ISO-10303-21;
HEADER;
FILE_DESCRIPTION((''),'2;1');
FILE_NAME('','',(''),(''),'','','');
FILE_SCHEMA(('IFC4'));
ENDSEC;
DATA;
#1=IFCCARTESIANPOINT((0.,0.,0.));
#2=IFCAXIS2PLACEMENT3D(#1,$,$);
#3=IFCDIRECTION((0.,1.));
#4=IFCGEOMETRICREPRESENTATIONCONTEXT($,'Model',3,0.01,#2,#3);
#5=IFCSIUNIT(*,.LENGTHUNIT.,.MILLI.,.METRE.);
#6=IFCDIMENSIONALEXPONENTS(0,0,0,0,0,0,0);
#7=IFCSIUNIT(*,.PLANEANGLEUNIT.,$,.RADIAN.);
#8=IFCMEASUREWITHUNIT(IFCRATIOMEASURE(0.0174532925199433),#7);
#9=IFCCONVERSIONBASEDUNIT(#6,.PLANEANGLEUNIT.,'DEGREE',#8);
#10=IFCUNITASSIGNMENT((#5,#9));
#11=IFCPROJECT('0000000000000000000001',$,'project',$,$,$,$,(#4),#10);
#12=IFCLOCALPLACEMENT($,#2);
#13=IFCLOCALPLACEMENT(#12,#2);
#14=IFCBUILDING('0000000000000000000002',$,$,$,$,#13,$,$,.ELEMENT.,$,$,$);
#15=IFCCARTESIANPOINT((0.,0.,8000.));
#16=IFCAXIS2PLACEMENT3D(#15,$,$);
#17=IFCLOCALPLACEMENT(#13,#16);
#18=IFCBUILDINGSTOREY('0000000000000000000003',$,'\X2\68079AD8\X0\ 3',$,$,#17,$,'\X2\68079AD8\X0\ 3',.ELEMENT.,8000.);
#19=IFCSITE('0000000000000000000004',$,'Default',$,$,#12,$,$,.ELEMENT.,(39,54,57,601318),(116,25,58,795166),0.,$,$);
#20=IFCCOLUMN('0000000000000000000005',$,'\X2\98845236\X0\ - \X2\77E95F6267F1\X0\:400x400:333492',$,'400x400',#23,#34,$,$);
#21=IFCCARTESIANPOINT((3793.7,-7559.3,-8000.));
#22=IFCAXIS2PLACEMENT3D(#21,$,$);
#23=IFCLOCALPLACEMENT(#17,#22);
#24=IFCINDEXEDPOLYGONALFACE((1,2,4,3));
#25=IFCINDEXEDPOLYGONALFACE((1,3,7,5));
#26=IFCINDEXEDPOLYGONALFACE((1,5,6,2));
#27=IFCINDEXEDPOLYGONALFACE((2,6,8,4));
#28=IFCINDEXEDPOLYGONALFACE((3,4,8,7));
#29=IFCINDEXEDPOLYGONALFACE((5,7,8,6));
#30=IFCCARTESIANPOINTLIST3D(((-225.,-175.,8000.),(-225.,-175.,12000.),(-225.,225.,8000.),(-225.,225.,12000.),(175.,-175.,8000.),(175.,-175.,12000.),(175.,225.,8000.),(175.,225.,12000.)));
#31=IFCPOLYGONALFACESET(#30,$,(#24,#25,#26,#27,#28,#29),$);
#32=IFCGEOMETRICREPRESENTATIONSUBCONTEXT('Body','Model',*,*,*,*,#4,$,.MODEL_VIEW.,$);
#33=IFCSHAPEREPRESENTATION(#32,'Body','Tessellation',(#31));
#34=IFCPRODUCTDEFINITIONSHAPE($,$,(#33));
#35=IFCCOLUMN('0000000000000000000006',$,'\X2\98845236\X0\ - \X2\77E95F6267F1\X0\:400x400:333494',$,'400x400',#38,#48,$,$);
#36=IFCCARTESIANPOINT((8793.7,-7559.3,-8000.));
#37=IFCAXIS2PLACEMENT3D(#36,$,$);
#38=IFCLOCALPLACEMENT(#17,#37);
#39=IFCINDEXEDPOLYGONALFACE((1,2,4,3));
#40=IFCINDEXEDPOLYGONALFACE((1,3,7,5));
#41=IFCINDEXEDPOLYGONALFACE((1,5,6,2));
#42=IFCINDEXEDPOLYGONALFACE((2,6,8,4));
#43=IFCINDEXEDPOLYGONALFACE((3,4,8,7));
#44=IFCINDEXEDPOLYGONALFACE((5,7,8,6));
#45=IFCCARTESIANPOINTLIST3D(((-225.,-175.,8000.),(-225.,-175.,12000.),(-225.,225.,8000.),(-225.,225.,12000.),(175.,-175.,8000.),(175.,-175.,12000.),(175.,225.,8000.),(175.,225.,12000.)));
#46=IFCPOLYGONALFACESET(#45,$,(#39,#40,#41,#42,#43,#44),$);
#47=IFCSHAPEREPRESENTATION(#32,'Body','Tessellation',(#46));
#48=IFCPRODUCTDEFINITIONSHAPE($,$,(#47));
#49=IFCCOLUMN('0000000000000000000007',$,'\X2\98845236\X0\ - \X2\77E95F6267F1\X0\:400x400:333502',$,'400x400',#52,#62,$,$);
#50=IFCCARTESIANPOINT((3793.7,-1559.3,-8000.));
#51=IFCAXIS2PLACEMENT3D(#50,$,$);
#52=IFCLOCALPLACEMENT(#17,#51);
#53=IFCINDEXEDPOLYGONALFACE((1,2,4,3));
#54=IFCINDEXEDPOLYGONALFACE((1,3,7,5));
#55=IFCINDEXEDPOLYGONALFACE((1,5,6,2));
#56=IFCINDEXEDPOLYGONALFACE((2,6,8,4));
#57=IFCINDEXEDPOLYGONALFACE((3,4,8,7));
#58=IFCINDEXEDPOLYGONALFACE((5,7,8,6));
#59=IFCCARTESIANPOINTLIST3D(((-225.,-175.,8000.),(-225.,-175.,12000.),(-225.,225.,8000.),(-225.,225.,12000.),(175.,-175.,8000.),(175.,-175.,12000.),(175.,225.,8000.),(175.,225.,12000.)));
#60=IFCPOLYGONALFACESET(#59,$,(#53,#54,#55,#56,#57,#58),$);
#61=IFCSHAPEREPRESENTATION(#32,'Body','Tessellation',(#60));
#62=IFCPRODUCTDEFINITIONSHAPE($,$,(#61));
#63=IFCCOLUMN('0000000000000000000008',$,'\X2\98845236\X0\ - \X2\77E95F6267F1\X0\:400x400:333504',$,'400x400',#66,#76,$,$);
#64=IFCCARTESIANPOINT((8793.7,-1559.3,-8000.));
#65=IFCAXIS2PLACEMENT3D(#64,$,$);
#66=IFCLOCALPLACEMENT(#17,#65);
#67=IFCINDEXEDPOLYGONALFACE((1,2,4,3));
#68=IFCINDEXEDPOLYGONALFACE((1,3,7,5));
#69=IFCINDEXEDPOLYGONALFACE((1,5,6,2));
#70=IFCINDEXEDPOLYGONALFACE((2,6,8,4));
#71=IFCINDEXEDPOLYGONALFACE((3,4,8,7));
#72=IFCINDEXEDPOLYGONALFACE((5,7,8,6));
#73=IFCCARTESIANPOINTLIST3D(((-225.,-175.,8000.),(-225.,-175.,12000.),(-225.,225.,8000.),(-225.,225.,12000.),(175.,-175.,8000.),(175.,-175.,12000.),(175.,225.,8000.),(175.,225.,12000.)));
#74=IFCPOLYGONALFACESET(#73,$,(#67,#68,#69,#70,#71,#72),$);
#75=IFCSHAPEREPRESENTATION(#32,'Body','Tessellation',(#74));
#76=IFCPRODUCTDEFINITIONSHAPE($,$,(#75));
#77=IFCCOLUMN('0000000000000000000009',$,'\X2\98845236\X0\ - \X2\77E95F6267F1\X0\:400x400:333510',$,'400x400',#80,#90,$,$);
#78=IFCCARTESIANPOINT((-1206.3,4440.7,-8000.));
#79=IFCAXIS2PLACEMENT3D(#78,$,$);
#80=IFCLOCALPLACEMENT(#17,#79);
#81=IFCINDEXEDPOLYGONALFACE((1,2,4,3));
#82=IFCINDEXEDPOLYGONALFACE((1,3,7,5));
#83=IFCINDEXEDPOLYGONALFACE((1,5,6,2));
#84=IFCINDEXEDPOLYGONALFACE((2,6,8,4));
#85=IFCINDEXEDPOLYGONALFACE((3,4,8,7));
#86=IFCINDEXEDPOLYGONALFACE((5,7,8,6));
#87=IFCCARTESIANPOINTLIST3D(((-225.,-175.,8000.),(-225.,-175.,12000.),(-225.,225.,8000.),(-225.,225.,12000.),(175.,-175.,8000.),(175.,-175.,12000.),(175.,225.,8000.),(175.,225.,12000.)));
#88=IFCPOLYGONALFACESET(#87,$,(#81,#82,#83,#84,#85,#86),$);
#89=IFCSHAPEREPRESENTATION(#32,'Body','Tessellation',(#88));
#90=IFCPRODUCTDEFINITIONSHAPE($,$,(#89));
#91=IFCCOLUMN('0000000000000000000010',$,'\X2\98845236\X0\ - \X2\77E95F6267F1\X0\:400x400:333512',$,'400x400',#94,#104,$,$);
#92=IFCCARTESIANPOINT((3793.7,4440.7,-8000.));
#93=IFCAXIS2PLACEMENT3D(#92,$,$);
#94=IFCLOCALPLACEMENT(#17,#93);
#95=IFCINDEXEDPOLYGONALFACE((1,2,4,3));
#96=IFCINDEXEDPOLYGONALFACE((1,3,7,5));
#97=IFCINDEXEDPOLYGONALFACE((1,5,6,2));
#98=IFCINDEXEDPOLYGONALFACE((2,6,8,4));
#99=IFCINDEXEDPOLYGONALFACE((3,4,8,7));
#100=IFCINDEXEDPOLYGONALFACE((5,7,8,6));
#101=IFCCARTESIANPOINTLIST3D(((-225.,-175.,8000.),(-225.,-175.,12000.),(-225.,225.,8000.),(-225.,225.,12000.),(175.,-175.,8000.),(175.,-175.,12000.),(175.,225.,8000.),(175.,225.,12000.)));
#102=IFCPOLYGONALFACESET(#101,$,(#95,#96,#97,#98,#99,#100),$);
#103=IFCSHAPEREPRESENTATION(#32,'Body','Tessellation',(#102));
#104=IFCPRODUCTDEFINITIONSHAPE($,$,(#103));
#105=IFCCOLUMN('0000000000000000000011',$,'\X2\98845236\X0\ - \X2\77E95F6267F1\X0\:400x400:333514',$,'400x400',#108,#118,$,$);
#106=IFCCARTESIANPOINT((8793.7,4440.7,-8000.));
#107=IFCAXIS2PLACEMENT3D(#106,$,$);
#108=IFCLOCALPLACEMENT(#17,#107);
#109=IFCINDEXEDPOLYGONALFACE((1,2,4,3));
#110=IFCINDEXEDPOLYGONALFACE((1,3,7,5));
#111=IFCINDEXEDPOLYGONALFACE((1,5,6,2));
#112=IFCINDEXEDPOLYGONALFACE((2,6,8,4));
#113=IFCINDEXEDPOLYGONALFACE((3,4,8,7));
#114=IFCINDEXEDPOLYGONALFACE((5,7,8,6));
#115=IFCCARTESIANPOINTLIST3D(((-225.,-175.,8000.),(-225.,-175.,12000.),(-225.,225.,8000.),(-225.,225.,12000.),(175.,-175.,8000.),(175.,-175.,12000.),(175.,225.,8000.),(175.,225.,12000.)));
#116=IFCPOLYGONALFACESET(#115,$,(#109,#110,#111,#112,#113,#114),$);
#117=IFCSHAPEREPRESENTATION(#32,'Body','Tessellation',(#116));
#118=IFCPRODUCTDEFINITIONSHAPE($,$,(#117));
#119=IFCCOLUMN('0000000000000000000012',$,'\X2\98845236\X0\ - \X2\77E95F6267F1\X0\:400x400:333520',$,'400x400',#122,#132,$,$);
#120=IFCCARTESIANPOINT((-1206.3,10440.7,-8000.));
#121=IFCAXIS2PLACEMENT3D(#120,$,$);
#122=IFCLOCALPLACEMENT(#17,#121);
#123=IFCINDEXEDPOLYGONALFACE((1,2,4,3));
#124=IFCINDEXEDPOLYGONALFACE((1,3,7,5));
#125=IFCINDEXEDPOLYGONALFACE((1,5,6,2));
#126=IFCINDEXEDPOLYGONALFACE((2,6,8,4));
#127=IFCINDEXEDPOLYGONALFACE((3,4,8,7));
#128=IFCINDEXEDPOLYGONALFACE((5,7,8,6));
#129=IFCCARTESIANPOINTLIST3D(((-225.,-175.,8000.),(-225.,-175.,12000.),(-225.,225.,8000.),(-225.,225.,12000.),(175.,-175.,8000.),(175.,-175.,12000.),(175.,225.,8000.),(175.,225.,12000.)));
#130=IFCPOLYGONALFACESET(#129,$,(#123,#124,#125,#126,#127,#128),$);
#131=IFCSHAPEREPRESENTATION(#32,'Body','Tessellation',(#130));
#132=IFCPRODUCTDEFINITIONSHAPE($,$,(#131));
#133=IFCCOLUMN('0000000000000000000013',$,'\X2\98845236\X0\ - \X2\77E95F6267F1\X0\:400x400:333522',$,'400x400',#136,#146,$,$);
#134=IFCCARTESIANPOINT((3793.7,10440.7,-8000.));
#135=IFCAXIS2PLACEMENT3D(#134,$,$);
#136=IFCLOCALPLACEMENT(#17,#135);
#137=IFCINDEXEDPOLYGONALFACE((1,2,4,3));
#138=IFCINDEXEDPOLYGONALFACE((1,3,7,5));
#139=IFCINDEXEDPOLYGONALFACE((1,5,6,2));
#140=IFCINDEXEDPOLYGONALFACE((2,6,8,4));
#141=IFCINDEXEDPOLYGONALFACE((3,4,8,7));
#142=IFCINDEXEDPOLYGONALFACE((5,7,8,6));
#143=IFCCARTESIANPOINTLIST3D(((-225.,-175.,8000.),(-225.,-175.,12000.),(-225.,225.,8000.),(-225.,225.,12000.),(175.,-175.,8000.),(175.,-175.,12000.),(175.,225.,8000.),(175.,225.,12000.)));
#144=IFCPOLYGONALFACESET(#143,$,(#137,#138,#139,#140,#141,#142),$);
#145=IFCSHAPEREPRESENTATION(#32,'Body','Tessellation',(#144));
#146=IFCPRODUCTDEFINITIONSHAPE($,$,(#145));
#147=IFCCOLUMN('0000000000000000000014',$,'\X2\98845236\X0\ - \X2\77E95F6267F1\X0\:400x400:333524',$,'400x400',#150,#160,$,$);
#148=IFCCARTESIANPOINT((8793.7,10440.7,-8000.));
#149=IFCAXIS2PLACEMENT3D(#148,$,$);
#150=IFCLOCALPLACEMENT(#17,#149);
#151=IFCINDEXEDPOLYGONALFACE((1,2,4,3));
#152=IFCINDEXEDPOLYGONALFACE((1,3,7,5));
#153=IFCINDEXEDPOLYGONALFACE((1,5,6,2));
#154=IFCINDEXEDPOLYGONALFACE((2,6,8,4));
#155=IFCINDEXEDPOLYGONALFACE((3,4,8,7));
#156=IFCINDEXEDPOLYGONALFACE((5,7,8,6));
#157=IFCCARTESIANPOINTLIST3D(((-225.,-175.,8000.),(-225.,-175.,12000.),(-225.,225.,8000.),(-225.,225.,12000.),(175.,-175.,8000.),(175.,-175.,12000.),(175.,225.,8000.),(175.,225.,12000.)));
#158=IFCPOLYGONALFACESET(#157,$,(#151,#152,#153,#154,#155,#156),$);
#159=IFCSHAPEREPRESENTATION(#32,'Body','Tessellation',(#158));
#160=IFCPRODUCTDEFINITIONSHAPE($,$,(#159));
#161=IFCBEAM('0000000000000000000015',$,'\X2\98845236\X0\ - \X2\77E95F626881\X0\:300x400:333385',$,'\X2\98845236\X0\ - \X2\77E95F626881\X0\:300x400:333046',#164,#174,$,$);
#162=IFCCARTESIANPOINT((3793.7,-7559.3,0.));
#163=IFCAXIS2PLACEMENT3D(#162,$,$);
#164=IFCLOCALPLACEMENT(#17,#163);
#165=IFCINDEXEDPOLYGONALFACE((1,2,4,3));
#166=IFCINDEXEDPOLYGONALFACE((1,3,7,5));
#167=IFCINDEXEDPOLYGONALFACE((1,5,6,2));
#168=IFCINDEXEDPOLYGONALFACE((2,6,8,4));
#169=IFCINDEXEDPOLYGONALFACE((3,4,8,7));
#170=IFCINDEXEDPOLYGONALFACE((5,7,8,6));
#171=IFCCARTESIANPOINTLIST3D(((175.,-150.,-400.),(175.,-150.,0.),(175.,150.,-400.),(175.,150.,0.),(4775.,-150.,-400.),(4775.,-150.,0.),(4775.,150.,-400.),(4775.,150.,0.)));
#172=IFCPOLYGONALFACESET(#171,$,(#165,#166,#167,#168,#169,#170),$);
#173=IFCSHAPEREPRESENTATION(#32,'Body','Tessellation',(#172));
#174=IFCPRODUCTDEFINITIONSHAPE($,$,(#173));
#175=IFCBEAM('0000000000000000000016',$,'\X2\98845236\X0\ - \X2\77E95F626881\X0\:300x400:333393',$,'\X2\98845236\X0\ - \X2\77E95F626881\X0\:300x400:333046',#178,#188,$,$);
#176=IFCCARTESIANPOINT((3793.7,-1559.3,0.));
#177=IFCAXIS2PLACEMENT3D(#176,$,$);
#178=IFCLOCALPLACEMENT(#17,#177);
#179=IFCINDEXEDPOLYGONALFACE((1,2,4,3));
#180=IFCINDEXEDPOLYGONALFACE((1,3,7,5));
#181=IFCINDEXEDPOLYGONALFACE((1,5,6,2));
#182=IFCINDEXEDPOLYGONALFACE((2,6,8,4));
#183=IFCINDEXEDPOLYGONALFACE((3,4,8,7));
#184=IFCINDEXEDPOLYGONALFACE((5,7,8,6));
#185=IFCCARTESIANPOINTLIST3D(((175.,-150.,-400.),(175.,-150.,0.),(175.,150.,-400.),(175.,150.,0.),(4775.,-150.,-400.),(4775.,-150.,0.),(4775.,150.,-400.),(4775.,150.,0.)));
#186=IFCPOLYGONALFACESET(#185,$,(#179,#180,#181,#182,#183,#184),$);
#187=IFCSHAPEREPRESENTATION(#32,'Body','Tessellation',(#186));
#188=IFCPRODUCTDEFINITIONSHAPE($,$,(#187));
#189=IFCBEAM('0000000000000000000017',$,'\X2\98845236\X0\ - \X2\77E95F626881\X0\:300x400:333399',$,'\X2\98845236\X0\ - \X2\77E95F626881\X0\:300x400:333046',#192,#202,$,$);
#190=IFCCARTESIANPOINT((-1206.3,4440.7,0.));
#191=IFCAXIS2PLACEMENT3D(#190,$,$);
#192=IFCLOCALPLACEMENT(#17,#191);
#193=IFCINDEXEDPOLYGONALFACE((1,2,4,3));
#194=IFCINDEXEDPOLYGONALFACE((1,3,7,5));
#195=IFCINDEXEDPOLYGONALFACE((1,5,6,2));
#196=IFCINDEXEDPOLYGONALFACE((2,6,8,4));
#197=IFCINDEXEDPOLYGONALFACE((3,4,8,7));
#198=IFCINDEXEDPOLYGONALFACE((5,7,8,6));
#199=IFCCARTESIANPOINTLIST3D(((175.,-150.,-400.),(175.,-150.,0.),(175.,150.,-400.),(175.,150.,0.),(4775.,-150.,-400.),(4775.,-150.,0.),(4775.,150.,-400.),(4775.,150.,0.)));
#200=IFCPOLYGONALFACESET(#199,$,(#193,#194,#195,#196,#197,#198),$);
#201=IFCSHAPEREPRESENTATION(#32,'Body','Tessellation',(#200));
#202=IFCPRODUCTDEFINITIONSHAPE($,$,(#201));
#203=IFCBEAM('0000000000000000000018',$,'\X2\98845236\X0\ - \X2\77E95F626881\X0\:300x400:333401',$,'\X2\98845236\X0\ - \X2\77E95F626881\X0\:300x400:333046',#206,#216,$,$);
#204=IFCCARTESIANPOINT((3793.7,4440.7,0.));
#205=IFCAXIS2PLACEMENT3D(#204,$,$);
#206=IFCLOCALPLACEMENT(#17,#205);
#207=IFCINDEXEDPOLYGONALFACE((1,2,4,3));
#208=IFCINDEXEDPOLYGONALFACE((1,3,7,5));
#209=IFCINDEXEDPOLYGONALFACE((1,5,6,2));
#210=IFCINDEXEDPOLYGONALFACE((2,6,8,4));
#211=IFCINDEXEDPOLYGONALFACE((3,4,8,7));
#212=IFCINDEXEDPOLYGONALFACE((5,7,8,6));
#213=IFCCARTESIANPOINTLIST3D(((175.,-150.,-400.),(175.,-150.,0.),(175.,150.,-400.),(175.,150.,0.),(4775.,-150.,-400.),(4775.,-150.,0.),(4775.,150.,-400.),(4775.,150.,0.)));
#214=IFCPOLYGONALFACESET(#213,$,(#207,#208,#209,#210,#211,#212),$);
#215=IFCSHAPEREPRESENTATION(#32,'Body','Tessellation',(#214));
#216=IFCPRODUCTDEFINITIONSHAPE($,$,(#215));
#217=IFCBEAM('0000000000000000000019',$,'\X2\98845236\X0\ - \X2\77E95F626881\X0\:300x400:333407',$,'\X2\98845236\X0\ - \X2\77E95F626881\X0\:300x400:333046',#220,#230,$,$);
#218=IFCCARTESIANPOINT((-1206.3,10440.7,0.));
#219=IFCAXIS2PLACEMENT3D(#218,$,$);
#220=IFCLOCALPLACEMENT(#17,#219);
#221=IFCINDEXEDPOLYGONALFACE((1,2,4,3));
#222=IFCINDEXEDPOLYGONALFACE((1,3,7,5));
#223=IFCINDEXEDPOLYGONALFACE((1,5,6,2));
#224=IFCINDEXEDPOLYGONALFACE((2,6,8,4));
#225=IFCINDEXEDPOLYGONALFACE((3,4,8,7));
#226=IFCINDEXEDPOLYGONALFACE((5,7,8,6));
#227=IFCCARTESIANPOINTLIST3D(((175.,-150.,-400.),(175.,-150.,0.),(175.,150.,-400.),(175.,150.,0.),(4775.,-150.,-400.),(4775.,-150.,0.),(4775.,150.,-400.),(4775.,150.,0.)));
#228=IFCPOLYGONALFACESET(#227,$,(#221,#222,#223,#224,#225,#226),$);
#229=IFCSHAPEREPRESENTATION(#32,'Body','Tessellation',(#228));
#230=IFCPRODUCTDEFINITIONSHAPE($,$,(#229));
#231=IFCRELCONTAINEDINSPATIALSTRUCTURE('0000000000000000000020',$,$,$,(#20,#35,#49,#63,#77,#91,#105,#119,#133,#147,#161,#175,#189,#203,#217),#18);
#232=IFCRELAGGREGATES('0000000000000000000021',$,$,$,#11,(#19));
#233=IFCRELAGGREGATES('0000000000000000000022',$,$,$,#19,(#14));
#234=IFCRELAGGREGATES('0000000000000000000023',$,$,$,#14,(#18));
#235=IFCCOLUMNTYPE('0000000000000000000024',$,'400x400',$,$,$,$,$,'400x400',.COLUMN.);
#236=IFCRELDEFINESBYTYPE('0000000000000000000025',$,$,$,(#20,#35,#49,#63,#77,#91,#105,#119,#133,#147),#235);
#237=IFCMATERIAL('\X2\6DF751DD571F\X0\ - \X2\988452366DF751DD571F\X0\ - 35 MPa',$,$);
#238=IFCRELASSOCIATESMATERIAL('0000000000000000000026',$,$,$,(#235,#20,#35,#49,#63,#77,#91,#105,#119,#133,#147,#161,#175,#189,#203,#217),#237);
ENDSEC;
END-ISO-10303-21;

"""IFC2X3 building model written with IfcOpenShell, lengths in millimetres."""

from ifc_helpers import new_model, entity, si_unit, converted_unit, direction, frame, frame_2d, origin, place, context, subcontext, project, spatial, rectangle, extrude, source, transform, mapped, material, type_object, type_shapes, element, save


model = new_model("IFC2X3")

# Units and contexts
model_context = context("Model", 3, precision=0.01, world=origin(), true_north=direction((0.0, 1.0)))
body_context = subcontext(model_context, "Body", "Model", "MODEL_VIEW")
ifc_project = project(units=[si_unit("LENGTHUNIT", "METRE", prefix="MILLI"), converted_unit("PLANEANGLEUNIT", "DEGREE", entity("IfcRatioMeasure", 0.0174532925199433), si_unit("PLANEANGLEUNIT", "RADIAN"), dimensions=[0, 0, 0, 0, 0, 0, 0])], contexts=[model_context])

# Site, building, storey
site_placement = place(None, origin())
site = spatial("IfcSite", under=ifc_project, at=site_placement, Name="Default", CompositionType="ELEMENT", RefLatitude=(39, 54, 57, 601318), RefLongitude=(116, 25, 58, 795166), RefElevation=0.0)
building_placement = place(site_placement, origin())
building = spatial("IfcBuilding", under=site, at=building_placement, CompositionType="ELEMENT")
storey_placement = place(building_placement, frame((0.0, 0.0, 8000.0)))
storey = spatial("IfcBuildingStorey", under=building, at=storey_placement, Name="标高 3", LongName="标高 3", CompositionType="ELEMENT", Elevation=8000.0)

# Columns
ifc_material_1 = material(Name="混凝土 - 预制混凝土 - 35 MPa")
column_type = type_object("IfcColumnType", Name="400x400", ElementType="400x400", PredefinedType="COLUMN", material=ifc_material_1)
shared_shape = source(origin(), body_context, "Body", "SweptSolid", [
    extrude(rectangle(XDim=400.0, YDim=400.0, at=frame_2d((0.0, 0.0), x_axis=(1.0, 0.0))), frame((-25.0, 25.0, 8000.0)), (0.0, 0.0, 1.0), 4000.0),
])
type_shapes(column_type, [shared_shape])
for number, where, name in (
    (1, (3793.7, -7559.3, -8000.0), "预制 - 矩形柱:400x400:333492"),
    (2, (8793.7, -7559.3, -8000.0), "预制 - 矩形柱:400x400:333494"),
    (3, (3793.7, -1559.3, -8000.0), "预制 - 矩形柱:400x400:333502"),
    (4, (8793.7, -1559.3, -8000.0), "预制 - 矩形柱:400x400:333504"),
    (5, (-1206.3, 4440.7, -8000.0), "预制 - 矩形柱:400x400:333510"),
    (6, (3793.7, 4440.7, -8000.0), "预制 - 矩形柱:400x400:333512"),
    (7, (8793.7, 4440.7, -8000.0), "预制 - 矩形柱:400x400:333514"),
    (8, (-1206.3, 10440.7, -8000.0), "预制 - 矩形柱:400x400:333520"),
    (9, (3793.7, 10440.7, -8000.0), "预制 - 矩形柱:400x400:333522"),
    (10, (8793.7, 10440.7, -8000.0), "预制 - 矩形柱:400x400:333524"),
):
    element("IfcColumn", number, at=place(storey_placement, frame(where)), inside=storey, type_object=column_type, material=ifc_material_1, Name=name, ObjectType="400x400", context=body_context, shape_type="MappedRepresentation", body=[
        mapped(shared_shape, transform((0.0, 0.0, 0.0), scale=1.0)),
    ])

# Beams
beam_1_placement = place(storey_placement, frame((3793.7, -7559.3, 0.0)))
element("IfcBeam", 11, at=beam_1_placement, inside=storey, material=ifc_material_1, Name="预制 - 矩形梁:300x400:333385", ObjectType="预制 - 矩形梁:300x400:333046", context=body_context, shape_type="SweptSolid", body=[
    extrude(rectangle(XDim=400.0, YDim=300.0, at=frame_2d((0.0, 0.0), x_axis=(1.0, 0.0))), frame((175.0, 0.0, -200.0), z_axis=(1.0, 0.0, 0.0), x_axis=(0.0, 0.0, -1.0)), (0.0, 0.0, 1.0), 4600.0),
])
beam_2_placement = place(storey_placement, frame((3793.7, -1559.3, 0.0)))
element("IfcBeam", 12, at=beam_2_placement, inside=storey, material=ifc_material_1, Name="预制 - 矩形梁:300x400:333393", ObjectType="预制 - 矩形梁:300x400:333046", context=body_context, shape_type="SweptSolid", body=[
    extrude(rectangle(XDim=400.0, YDim=300.0, at=frame_2d((0.0, 0.0), x_axis=(1.0, 0.0))), frame((175.0, 0.0, -200.0), z_axis=(1.0, 0.0, 0.0), x_axis=(0.0, 0.0, -1.0)), (0.0, 0.0, 1.0), 4600.0),
])
beam_3_placement = place(storey_placement, frame((-1206.3, 4440.7, 0.0)))
element("IfcBeam", 13, at=beam_3_placement, inside=storey, material=ifc_material_1, Name="预制 - 矩形梁:300x400:333399", ObjectType="预制 - 矩形梁:300x400:333046", context=body_context, shape_type="SweptSolid", body=[
    extrude(rectangle(XDim=400.0, YDim=300.0, at=frame_2d((0.0, 0.0), x_axis=(1.0, 0.0))), frame((175.0, 0.0, -200.0), z_axis=(1.0, 0.0, 0.0), x_axis=(0.0, 0.0, -1.0)), (0.0, 0.0, 1.0), 4600.0),
])
beam_4_placement = place(storey_placement, frame((3793.7, 4440.7, 0.0)))
element("IfcBeam", 14, at=beam_4_placement, inside=storey, material=ifc_material_1, Name="预制 - 矩形梁:300x400:333401", ObjectType="预制 - 矩形梁:300x400:333046", context=body_context, shape_type="SweptSolid", body=[
    extrude(rectangle(XDim=400.0, YDim=300.0, at=frame_2d((0.0, 0.0), x_axis=(1.0, 0.0))), frame((175.0, 0.0, -200.0), z_axis=(1.0, 0.0, 0.0), x_axis=(0.0, 0.0, -1.0)), (0.0, 0.0, 1.0), 4600.0),
])
beam_5_placement = place(storey_placement, frame((-1206.3, 10440.7, 0.0)))
element("IfcBeam", 15, at=beam_5_placement, inside=storey, material=ifc_material_1, Name="预制 - 矩形梁:300x400:333407", ObjectType="预制 - 矩形梁:300x400:333046", context=body_context, shape_type="SweptSolid", body=[
    extrude(rectangle(XDim=400.0, YDim=300.0, at=frame_2d((0.0, 0.0), x_axis=(1.0, 0.0))), frame((175.0, 0.0, -200.0), z_axis=(1.0, 0.0, 0.0), x_axis=(0.0, 0.0, -1.0)), (0.0, 0.0, 1.0), 4600.0),
])

save(model, "model.ifc")
